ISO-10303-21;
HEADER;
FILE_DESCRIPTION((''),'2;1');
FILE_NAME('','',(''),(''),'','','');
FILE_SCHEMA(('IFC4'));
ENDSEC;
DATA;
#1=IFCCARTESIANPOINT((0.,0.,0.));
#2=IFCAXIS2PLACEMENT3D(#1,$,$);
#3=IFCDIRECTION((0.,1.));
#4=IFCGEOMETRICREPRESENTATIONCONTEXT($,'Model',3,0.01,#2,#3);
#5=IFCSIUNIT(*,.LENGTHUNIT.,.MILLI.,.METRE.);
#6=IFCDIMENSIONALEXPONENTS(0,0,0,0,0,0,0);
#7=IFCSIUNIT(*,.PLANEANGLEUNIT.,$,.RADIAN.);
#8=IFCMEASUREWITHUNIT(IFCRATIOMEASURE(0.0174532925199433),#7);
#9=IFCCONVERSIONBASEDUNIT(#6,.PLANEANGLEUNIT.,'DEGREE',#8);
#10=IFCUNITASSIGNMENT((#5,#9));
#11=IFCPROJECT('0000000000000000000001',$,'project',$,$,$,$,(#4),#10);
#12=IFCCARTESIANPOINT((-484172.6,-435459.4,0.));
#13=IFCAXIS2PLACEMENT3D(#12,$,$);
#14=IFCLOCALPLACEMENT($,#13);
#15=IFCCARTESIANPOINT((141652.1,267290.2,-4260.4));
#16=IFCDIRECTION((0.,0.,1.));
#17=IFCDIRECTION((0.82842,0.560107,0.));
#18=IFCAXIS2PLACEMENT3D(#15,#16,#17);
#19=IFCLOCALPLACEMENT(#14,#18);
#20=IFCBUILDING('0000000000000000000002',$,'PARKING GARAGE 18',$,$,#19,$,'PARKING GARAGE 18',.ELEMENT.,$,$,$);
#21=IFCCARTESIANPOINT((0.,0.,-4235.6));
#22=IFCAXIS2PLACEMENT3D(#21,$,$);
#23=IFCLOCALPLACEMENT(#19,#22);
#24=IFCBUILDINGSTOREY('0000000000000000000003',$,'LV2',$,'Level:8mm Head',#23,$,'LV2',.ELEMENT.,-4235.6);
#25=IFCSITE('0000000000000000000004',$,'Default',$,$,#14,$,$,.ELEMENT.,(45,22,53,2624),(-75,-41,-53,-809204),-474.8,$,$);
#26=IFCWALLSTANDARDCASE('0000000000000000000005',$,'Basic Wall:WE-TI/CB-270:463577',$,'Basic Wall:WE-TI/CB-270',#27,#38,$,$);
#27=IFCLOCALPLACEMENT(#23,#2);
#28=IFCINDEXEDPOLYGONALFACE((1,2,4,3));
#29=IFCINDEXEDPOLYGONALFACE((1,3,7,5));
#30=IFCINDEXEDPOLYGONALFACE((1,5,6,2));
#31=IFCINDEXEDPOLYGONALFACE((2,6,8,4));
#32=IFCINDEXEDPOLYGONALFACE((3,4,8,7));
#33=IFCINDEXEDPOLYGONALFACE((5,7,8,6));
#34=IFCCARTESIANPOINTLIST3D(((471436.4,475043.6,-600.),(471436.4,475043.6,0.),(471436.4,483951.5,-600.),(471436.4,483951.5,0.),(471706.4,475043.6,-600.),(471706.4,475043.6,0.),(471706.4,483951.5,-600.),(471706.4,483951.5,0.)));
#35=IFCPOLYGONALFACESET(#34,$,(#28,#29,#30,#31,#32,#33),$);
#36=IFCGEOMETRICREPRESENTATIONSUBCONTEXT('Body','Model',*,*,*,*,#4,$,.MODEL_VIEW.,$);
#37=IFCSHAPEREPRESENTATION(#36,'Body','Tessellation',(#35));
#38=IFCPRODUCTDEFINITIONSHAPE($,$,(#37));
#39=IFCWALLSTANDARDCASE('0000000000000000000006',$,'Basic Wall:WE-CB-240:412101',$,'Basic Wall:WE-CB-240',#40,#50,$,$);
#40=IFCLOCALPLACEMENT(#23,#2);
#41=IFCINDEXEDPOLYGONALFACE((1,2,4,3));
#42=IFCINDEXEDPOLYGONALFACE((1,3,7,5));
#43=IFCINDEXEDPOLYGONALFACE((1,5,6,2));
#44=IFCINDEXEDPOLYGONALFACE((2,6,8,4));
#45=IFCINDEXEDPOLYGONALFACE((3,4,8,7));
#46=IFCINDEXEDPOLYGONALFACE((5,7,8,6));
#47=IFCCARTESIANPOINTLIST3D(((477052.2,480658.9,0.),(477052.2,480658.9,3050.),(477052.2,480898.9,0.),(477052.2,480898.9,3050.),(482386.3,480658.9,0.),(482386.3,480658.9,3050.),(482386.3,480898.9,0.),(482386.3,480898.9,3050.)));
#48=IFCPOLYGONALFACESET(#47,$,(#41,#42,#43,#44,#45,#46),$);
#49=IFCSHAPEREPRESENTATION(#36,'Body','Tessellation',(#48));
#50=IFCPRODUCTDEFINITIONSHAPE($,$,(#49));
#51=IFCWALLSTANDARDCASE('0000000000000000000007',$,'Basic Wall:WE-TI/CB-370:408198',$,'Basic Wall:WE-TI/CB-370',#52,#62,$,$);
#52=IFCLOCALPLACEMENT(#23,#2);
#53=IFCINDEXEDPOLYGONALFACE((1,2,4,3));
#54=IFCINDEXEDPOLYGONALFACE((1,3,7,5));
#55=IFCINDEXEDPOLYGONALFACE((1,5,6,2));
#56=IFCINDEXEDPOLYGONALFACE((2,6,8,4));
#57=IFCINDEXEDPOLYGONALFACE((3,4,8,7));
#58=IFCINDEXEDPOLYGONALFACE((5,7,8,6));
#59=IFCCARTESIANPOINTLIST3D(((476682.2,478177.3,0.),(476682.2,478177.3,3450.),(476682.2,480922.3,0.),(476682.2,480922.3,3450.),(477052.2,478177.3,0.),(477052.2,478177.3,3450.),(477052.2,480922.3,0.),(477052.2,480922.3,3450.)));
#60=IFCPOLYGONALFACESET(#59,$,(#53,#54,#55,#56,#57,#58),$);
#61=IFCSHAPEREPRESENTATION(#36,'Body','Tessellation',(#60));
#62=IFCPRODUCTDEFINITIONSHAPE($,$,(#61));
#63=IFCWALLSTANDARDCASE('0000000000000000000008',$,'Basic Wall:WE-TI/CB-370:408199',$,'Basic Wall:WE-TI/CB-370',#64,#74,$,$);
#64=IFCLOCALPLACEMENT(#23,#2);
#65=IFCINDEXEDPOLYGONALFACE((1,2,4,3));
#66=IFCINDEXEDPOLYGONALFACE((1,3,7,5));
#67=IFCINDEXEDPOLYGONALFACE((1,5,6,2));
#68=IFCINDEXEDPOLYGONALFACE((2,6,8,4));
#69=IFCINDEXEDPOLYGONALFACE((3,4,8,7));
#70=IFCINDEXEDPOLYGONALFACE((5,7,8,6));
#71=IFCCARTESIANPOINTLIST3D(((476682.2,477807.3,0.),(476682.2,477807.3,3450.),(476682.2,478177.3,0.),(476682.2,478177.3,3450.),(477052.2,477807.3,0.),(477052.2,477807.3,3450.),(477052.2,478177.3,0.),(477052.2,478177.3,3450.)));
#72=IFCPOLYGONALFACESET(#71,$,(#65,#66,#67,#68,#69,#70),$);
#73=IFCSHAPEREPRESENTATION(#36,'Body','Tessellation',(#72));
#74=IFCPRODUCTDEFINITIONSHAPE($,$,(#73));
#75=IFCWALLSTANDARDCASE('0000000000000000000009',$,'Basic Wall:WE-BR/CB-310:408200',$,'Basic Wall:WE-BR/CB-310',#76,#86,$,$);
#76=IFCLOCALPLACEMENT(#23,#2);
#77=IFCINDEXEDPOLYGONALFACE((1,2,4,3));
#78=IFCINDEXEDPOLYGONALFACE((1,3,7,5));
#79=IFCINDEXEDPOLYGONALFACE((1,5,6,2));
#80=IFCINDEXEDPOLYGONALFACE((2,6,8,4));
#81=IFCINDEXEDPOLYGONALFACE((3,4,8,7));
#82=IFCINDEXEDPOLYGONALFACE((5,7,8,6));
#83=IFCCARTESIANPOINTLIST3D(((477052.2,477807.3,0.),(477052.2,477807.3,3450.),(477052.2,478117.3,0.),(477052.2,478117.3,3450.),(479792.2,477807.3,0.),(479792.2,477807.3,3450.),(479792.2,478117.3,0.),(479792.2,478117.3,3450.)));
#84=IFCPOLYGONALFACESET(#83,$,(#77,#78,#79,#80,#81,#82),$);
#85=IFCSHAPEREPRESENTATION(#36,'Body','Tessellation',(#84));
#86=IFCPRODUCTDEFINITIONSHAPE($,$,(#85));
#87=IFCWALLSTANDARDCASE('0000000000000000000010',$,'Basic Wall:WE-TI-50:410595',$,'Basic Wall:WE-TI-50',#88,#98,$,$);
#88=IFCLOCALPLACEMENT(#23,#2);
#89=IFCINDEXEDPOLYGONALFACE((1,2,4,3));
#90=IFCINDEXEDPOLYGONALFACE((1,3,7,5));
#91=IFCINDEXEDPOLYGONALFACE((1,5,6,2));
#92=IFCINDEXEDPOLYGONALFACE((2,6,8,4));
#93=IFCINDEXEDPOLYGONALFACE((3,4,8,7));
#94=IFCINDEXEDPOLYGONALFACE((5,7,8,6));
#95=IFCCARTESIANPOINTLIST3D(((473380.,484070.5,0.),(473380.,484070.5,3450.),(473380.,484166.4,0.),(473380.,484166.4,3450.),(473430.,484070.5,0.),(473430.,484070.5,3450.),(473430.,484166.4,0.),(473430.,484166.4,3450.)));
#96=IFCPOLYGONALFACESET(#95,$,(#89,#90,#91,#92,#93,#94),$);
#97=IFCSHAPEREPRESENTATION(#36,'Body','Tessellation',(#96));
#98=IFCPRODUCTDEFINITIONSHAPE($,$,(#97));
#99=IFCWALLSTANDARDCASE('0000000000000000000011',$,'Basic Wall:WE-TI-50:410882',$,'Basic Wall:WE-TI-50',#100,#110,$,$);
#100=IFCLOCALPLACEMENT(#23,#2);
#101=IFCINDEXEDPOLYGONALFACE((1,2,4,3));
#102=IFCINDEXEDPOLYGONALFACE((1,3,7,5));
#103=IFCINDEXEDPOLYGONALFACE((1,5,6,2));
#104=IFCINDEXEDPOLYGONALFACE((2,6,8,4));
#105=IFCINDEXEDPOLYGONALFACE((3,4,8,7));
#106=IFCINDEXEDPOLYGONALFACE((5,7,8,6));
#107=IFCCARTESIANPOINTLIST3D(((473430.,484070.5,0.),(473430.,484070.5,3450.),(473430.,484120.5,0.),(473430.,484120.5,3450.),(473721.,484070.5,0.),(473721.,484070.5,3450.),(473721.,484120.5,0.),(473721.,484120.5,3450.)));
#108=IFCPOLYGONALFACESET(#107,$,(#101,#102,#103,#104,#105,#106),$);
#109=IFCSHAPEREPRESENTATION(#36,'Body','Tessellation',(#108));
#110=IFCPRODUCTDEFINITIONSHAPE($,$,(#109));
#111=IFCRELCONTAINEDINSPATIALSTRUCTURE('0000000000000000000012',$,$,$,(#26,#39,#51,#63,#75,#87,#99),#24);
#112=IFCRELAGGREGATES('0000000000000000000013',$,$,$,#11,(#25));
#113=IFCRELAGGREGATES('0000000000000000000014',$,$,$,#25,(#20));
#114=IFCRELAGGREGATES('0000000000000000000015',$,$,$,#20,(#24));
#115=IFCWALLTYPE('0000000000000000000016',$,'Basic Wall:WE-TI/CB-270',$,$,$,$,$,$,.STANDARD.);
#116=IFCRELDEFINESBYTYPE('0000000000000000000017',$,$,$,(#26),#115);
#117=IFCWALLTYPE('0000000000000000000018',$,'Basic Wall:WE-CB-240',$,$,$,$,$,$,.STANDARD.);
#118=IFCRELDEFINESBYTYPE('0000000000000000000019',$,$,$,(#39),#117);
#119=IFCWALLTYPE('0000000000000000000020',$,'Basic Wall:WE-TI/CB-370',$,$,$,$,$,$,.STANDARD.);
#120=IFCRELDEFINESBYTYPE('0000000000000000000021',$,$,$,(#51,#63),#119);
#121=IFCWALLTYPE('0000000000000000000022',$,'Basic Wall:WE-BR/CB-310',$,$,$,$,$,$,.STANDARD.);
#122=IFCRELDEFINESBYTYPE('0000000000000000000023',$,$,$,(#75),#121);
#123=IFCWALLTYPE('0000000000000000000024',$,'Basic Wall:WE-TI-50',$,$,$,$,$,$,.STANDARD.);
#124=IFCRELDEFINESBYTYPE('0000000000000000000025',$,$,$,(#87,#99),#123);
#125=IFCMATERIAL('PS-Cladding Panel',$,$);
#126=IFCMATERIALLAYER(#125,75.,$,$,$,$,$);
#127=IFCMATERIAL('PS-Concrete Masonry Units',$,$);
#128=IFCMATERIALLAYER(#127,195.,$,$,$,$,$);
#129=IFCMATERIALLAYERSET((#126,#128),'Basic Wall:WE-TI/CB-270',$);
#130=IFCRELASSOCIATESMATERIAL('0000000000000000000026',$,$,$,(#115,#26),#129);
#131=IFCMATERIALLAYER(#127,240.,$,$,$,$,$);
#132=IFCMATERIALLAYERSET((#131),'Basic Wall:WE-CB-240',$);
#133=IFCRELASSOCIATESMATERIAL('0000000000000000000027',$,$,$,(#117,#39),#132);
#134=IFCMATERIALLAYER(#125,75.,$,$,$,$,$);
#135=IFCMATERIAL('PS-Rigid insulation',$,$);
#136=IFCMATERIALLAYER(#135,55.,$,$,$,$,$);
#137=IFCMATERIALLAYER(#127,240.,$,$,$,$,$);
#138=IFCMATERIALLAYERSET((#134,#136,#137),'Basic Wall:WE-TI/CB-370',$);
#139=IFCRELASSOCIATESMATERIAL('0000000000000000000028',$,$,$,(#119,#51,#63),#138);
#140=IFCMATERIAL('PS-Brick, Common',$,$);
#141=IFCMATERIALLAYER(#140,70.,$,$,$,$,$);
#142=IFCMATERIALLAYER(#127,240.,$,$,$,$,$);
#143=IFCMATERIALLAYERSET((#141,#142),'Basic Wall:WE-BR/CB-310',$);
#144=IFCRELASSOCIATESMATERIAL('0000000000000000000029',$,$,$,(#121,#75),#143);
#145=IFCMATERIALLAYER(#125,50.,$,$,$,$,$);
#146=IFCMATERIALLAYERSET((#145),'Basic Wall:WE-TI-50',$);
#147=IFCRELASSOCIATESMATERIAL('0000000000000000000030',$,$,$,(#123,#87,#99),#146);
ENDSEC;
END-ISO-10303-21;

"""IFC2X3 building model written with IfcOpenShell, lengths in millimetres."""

from ifc_helpers import new_model, entity, si_unit, converted_unit, direction, frame, frame_2d, origin, place, context, subcontext, project, spatial, rectangle, extrude, material, layer, layer_set, layer_usage, type_object, element, save


model = new_model("IFC2X3")

# Units and contexts
model_context = context("Model", 3, precision=0.01, world=origin(), true_north=direction((0.0, 1.0)))
body_context = subcontext(model_context, "Body", "Model", "MODEL_VIEW")
ifc_project = project(units=[si_unit("LENGTHUNIT", "METRE", prefix="MILLI"), converted_unit("PLANEANGLEUNIT", "DEGREE", entity("IfcRatioMeasure", 0.0174532925199433), si_unit("PLANEANGLEUNIT", "RADIAN"), dimensions=[0, 0, 0, 0, 0, 0, 0])], contexts=[model_context])

# Site, building, storey
site_placement = place(None, frame((-484172.6, -435459.4, 0.0)))
site = spatial("IfcSite", under=ifc_project, at=site_placement, Name="Default", CompositionType="ELEMENT", RefLatitude=(45, 22, 53, 2624), RefLongitude=(-75, -41, -53, -809204), RefElevation=-474.8)
building_placement = place(site_placement, frame((141652.1, 267290.2, -4260.4), z_axis=(0.0, 0.0, 1.0), x_axis=(0.82842, 0.560107, 0.0)))
building = spatial("IfcBuilding", under=site, at=building_placement, Name="PARKING GARAGE 18", LongName="PARKING GARAGE 18", CompositionType="ELEMENT")
storey_placement = place(building_placement, frame((0.0, 0.0, -4235.6)))
storey = spatial("IfcBuildingStorey", under=building, at=storey_placement, Name="LV2", ObjectType="Level:8mm Head", LongName="LV2", CompositionType="ELEMENT", Elevation=-4235.6)

# Walls
ifc_material_1 = material(Name="PS-Cladding Panel")
ifc_layer_1 = layer(ifc_material_1, 75.0)
ifc_material_2 = material(Name="PS-Concrete Masonry Units")
ifc_layer_2 = layer(ifc_material_2, 195.0)
ifc_layer_set_1 = layer_set([ifc_layer_1, ifc_layer_2], Name="Basic Wall:WE-TI/CB-270")
wall_type_1 = type_object("IfcWallType", Name="Basic Wall:WE-TI/CB-270", PredefinedType="STANDARD", material=ifc_layer_set_1)
ifc_layer_usage_1 = layer_usage(ifc_layer_set_1, "AXIS2", "NEGATIVE", 135.0)
wall_1_placement = place(storey_placement, frame((471571.4, 475043.6, -600.0), z_axis=(0.0, 0.0, 1.0), x_axis=(0.0, 1.0, 0.0)))
element("IfcWallStandardCase", 1, at=wall_1_placement, inside=storey, type_object=wall_type_1, material=ifc_layer_usage_1, Name="Basic Wall:WE-TI/CB-270:463577", ObjectType="Basic Wall:WE-TI/CB-270", context=body_context, shape_type="SweptSolid", body=[
    extrude(rectangle(XDim=8907.9, YDim=270.0, at=frame_2d((4453.9, 0.0), x_axis=(-1.0, 0.0))), origin(), (0.0, 0.0, 1.0), 600.0),
])
ifc_layer_3 = layer(ifc_material_2, 240.0)
ifc_layer_set_2 = layer_set([ifc_layer_3], Name="Basic Wall:WE-CB-240")
ifc_layer_usage_2 = layer_usage(ifc_layer_set_2, "AXIS2", "NEGATIVE", 120.0)
wall_type_2 = type_object("IfcWallType", Name="Basic Wall:WE-CB-240", PredefinedType="STANDARD", material=ifc_layer_set_2)
wall_2_placement = place(storey_placement, frame((477052.2, 480778.9, 0.0)))
element("IfcWallStandardCase", 2, at=wall_2_placement, inside=storey, type_object=wall_type_2, material=ifc_layer_usage_2, Name="Basic Wall:WE-CB-240:412101", ObjectType="Basic Wall:WE-CB-240", context=body_context, shape_type="SweptSolid", body=[
    extrude(rectangle(XDim=5334.1, YDim=240.0, at=frame_2d((2667.0, 0.0), x_axis=(-1.0, 0.0))), origin(), (0.0, 0.0, 1.0), 3050.0),
])
ifc_layer_4 = layer(ifc_material_1, 75.0)
ifc_material_3 = material(Name="PS-Rigid insulation")
ifc_layer_5 = layer(ifc_material_3, 55.0)
ifc_layer_6 = layer(ifc_material_2, 240.0)
ifc_layer_set_3 = layer_set([ifc_layer_4, ifc_layer_5, ifc_layer_6], Name="Basic Wall:WE-TI/CB-370")
ifc_layer_usage_3 = layer_usage(ifc_layer_set_3, "AXIS2", "NEGATIVE", 185.0)
wall_type_3 = type_object("IfcWallType", Name="Basic Wall:WE-TI/CB-370", PredefinedType="STANDARD", material=ifc_layer_set_3)
wall_3_placement = place(storey_placement, frame((476867.2, 478177.3, 0.0), z_axis=(0.0, 0.0, 1.0), x_axis=(0.0, 1.0, 0.0)))
element("IfcWallStandardCase", 3, at=wall_3_placement, inside=storey, type_object=wall_type_3, material=ifc_layer_usage_3, Name="Basic Wall:WE-TI/CB-370:408198", ObjectType="Basic Wall:WE-TI/CB-370", context=body_context, shape_type="SweptSolid", body=[
    extrude(rectangle(XDim=2745.0, YDim=370.0, at=frame_2d((1372.5, 0.0), x_axis=(-1.0, 0.0))), origin(), (0.0, 0.0, 1.0), 3450.0),
])
ifc_layer_usage_4 = layer_usage(ifc_layer_set_3, "AXIS2", "POSITIVE", -185.0)
wall_4_placement = place(storey_placement, frame((476682.2, 477992.3, 0.0)))
element("IfcWallStandardCase", 4, at=wall_4_placement, inside=storey, type_object=wall_type_3, material=ifc_layer_usage_4, Name="Basic Wall:WE-TI/CB-370:408199", ObjectType="Basic Wall:WE-TI/CB-370", context=body_context, shape_type="SweptSolid", body=[
    extrude(rectangle(XDim=370.0, YDim=370.0, at=frame_2d((185.0, 0.0), x_axis=(-1.0, 0.0))), origin(), (0.0, 0.0, 1.0), 3450.0),
])
ifc_material_4 = material(Name="PS-Brick, Common")
ifc_layer_7 = layer(ifc_material_4, 70.0)
ifc_layer_8 = layer(ifc_material_2, 240.0)
ifc_layer_set_4 = layer_set([ifc_layer_7, ifc_layer_8], Name="Basic Wall:WE-BR/CB-310")
ifc_layer_usage_5 = layer_usage(ifc_layer_set_4, "AXIS2", "NEGATIVE", 155.0)
wall_type_4 = type_object("IfcWallType", Name="Basic Wall:WE-BR/CB-310", PredefinedType="STANDARD", material=ifc_layer_set_4)
wall_5_placement = place(storey_placement, frame((479792.2, 477962.3, 0.0), z_axis=(0.0, 0.0, 1.0), x_axis=(-1.0, 0.0, 0.0)))
element("IfcWallStandardCase", 5, at=wall_5_placement, inside=storey, type_object=wall_type_4, material=ifc_layer_usage_5, Name="Basic Wall:WE-BR/CB-310:408200", ObjectType="Basic Wall:WE-BR/CB-310", context=body_context, shape_type="SweptSolid", body=[
    extrude(rectangle(XDim=2740.0, YDim=310.0, at=frame_2d((1370.0, 0.0), x_axis=(-1.0, 0.0))), origin(), (0.0, 0.0, 1.0), 3450.0),
])
ifc_layer_9 = layer(ifc_material_1, 50.0)
ifc_layer_set_5 = layer_set([ifc_layer_9], Name="Basic Wall:WE-TI-50")
ifc_layer_usage_6 = layer_usage(ifc_layer_set_5, "AXIS2", "POSITIVE", -25.0)
wall_type_5 = type_object("IfcWallType", Name="Basic Wall:WE-TI-50", PredefinedType="STANDARD", material=ifc_layer_set_5)
wall_6_placement = place(storey_placement, frame((473405.0, 484166.4, 0.0), z_axis=(0.0, 0.0, 1.0), x_axis=(0.0, -1.0, 0.0)))
element("IfcWallStandardCase", 6, at=wall_6_placement, inside=storey, type_object=wall_type_5, material=ifc_layer_usage_6, Name="Basic Wall:WE-TI-50:410595", ObjectType="Basic Wall:WE-TI-50", context=body_context, shape_type="SweptSolid", body=[
    extrude(rectangle(XDim=95.9, YDim=50.0, at=frame_2d((48.0, 0.0), x_axis=(-1.0, 0.0))), origin(), (0.0, 0.0, 1.0), 3450.0),
])
ifc_layer_usage_7 = layer_usage(ifc_layer_set_5, "AXIS2", "NEGATIVE", 25.0)
wall_7_placement = place(storey_placement, frame((473721.0, 484095.5, 0.0), z_axis=(0.0, 0.0, 1.0), x_axis=(-1.0, 0.0, 0.0)))
element("IfcWallStandardCase", 7, at=wall_7_placement, inside=storey, type_object=wall_type_5, material=ifc_layer_usage_7, Name="Basic Wall:WE-TI-50:410882", ObjectType="Basic Wall:WE-TI-50", context=body_context, shape_type="SweptSolid", body=[
    extrude(rectangle(XDim=291.0, YDim=50.0, at=frame_2d((145.5, 0.0), x_axis=(-1.0, 0.0))), origin(), (0.0, 0.0, 1.0), 3450.0),
])

save(model, "model.ifc")
